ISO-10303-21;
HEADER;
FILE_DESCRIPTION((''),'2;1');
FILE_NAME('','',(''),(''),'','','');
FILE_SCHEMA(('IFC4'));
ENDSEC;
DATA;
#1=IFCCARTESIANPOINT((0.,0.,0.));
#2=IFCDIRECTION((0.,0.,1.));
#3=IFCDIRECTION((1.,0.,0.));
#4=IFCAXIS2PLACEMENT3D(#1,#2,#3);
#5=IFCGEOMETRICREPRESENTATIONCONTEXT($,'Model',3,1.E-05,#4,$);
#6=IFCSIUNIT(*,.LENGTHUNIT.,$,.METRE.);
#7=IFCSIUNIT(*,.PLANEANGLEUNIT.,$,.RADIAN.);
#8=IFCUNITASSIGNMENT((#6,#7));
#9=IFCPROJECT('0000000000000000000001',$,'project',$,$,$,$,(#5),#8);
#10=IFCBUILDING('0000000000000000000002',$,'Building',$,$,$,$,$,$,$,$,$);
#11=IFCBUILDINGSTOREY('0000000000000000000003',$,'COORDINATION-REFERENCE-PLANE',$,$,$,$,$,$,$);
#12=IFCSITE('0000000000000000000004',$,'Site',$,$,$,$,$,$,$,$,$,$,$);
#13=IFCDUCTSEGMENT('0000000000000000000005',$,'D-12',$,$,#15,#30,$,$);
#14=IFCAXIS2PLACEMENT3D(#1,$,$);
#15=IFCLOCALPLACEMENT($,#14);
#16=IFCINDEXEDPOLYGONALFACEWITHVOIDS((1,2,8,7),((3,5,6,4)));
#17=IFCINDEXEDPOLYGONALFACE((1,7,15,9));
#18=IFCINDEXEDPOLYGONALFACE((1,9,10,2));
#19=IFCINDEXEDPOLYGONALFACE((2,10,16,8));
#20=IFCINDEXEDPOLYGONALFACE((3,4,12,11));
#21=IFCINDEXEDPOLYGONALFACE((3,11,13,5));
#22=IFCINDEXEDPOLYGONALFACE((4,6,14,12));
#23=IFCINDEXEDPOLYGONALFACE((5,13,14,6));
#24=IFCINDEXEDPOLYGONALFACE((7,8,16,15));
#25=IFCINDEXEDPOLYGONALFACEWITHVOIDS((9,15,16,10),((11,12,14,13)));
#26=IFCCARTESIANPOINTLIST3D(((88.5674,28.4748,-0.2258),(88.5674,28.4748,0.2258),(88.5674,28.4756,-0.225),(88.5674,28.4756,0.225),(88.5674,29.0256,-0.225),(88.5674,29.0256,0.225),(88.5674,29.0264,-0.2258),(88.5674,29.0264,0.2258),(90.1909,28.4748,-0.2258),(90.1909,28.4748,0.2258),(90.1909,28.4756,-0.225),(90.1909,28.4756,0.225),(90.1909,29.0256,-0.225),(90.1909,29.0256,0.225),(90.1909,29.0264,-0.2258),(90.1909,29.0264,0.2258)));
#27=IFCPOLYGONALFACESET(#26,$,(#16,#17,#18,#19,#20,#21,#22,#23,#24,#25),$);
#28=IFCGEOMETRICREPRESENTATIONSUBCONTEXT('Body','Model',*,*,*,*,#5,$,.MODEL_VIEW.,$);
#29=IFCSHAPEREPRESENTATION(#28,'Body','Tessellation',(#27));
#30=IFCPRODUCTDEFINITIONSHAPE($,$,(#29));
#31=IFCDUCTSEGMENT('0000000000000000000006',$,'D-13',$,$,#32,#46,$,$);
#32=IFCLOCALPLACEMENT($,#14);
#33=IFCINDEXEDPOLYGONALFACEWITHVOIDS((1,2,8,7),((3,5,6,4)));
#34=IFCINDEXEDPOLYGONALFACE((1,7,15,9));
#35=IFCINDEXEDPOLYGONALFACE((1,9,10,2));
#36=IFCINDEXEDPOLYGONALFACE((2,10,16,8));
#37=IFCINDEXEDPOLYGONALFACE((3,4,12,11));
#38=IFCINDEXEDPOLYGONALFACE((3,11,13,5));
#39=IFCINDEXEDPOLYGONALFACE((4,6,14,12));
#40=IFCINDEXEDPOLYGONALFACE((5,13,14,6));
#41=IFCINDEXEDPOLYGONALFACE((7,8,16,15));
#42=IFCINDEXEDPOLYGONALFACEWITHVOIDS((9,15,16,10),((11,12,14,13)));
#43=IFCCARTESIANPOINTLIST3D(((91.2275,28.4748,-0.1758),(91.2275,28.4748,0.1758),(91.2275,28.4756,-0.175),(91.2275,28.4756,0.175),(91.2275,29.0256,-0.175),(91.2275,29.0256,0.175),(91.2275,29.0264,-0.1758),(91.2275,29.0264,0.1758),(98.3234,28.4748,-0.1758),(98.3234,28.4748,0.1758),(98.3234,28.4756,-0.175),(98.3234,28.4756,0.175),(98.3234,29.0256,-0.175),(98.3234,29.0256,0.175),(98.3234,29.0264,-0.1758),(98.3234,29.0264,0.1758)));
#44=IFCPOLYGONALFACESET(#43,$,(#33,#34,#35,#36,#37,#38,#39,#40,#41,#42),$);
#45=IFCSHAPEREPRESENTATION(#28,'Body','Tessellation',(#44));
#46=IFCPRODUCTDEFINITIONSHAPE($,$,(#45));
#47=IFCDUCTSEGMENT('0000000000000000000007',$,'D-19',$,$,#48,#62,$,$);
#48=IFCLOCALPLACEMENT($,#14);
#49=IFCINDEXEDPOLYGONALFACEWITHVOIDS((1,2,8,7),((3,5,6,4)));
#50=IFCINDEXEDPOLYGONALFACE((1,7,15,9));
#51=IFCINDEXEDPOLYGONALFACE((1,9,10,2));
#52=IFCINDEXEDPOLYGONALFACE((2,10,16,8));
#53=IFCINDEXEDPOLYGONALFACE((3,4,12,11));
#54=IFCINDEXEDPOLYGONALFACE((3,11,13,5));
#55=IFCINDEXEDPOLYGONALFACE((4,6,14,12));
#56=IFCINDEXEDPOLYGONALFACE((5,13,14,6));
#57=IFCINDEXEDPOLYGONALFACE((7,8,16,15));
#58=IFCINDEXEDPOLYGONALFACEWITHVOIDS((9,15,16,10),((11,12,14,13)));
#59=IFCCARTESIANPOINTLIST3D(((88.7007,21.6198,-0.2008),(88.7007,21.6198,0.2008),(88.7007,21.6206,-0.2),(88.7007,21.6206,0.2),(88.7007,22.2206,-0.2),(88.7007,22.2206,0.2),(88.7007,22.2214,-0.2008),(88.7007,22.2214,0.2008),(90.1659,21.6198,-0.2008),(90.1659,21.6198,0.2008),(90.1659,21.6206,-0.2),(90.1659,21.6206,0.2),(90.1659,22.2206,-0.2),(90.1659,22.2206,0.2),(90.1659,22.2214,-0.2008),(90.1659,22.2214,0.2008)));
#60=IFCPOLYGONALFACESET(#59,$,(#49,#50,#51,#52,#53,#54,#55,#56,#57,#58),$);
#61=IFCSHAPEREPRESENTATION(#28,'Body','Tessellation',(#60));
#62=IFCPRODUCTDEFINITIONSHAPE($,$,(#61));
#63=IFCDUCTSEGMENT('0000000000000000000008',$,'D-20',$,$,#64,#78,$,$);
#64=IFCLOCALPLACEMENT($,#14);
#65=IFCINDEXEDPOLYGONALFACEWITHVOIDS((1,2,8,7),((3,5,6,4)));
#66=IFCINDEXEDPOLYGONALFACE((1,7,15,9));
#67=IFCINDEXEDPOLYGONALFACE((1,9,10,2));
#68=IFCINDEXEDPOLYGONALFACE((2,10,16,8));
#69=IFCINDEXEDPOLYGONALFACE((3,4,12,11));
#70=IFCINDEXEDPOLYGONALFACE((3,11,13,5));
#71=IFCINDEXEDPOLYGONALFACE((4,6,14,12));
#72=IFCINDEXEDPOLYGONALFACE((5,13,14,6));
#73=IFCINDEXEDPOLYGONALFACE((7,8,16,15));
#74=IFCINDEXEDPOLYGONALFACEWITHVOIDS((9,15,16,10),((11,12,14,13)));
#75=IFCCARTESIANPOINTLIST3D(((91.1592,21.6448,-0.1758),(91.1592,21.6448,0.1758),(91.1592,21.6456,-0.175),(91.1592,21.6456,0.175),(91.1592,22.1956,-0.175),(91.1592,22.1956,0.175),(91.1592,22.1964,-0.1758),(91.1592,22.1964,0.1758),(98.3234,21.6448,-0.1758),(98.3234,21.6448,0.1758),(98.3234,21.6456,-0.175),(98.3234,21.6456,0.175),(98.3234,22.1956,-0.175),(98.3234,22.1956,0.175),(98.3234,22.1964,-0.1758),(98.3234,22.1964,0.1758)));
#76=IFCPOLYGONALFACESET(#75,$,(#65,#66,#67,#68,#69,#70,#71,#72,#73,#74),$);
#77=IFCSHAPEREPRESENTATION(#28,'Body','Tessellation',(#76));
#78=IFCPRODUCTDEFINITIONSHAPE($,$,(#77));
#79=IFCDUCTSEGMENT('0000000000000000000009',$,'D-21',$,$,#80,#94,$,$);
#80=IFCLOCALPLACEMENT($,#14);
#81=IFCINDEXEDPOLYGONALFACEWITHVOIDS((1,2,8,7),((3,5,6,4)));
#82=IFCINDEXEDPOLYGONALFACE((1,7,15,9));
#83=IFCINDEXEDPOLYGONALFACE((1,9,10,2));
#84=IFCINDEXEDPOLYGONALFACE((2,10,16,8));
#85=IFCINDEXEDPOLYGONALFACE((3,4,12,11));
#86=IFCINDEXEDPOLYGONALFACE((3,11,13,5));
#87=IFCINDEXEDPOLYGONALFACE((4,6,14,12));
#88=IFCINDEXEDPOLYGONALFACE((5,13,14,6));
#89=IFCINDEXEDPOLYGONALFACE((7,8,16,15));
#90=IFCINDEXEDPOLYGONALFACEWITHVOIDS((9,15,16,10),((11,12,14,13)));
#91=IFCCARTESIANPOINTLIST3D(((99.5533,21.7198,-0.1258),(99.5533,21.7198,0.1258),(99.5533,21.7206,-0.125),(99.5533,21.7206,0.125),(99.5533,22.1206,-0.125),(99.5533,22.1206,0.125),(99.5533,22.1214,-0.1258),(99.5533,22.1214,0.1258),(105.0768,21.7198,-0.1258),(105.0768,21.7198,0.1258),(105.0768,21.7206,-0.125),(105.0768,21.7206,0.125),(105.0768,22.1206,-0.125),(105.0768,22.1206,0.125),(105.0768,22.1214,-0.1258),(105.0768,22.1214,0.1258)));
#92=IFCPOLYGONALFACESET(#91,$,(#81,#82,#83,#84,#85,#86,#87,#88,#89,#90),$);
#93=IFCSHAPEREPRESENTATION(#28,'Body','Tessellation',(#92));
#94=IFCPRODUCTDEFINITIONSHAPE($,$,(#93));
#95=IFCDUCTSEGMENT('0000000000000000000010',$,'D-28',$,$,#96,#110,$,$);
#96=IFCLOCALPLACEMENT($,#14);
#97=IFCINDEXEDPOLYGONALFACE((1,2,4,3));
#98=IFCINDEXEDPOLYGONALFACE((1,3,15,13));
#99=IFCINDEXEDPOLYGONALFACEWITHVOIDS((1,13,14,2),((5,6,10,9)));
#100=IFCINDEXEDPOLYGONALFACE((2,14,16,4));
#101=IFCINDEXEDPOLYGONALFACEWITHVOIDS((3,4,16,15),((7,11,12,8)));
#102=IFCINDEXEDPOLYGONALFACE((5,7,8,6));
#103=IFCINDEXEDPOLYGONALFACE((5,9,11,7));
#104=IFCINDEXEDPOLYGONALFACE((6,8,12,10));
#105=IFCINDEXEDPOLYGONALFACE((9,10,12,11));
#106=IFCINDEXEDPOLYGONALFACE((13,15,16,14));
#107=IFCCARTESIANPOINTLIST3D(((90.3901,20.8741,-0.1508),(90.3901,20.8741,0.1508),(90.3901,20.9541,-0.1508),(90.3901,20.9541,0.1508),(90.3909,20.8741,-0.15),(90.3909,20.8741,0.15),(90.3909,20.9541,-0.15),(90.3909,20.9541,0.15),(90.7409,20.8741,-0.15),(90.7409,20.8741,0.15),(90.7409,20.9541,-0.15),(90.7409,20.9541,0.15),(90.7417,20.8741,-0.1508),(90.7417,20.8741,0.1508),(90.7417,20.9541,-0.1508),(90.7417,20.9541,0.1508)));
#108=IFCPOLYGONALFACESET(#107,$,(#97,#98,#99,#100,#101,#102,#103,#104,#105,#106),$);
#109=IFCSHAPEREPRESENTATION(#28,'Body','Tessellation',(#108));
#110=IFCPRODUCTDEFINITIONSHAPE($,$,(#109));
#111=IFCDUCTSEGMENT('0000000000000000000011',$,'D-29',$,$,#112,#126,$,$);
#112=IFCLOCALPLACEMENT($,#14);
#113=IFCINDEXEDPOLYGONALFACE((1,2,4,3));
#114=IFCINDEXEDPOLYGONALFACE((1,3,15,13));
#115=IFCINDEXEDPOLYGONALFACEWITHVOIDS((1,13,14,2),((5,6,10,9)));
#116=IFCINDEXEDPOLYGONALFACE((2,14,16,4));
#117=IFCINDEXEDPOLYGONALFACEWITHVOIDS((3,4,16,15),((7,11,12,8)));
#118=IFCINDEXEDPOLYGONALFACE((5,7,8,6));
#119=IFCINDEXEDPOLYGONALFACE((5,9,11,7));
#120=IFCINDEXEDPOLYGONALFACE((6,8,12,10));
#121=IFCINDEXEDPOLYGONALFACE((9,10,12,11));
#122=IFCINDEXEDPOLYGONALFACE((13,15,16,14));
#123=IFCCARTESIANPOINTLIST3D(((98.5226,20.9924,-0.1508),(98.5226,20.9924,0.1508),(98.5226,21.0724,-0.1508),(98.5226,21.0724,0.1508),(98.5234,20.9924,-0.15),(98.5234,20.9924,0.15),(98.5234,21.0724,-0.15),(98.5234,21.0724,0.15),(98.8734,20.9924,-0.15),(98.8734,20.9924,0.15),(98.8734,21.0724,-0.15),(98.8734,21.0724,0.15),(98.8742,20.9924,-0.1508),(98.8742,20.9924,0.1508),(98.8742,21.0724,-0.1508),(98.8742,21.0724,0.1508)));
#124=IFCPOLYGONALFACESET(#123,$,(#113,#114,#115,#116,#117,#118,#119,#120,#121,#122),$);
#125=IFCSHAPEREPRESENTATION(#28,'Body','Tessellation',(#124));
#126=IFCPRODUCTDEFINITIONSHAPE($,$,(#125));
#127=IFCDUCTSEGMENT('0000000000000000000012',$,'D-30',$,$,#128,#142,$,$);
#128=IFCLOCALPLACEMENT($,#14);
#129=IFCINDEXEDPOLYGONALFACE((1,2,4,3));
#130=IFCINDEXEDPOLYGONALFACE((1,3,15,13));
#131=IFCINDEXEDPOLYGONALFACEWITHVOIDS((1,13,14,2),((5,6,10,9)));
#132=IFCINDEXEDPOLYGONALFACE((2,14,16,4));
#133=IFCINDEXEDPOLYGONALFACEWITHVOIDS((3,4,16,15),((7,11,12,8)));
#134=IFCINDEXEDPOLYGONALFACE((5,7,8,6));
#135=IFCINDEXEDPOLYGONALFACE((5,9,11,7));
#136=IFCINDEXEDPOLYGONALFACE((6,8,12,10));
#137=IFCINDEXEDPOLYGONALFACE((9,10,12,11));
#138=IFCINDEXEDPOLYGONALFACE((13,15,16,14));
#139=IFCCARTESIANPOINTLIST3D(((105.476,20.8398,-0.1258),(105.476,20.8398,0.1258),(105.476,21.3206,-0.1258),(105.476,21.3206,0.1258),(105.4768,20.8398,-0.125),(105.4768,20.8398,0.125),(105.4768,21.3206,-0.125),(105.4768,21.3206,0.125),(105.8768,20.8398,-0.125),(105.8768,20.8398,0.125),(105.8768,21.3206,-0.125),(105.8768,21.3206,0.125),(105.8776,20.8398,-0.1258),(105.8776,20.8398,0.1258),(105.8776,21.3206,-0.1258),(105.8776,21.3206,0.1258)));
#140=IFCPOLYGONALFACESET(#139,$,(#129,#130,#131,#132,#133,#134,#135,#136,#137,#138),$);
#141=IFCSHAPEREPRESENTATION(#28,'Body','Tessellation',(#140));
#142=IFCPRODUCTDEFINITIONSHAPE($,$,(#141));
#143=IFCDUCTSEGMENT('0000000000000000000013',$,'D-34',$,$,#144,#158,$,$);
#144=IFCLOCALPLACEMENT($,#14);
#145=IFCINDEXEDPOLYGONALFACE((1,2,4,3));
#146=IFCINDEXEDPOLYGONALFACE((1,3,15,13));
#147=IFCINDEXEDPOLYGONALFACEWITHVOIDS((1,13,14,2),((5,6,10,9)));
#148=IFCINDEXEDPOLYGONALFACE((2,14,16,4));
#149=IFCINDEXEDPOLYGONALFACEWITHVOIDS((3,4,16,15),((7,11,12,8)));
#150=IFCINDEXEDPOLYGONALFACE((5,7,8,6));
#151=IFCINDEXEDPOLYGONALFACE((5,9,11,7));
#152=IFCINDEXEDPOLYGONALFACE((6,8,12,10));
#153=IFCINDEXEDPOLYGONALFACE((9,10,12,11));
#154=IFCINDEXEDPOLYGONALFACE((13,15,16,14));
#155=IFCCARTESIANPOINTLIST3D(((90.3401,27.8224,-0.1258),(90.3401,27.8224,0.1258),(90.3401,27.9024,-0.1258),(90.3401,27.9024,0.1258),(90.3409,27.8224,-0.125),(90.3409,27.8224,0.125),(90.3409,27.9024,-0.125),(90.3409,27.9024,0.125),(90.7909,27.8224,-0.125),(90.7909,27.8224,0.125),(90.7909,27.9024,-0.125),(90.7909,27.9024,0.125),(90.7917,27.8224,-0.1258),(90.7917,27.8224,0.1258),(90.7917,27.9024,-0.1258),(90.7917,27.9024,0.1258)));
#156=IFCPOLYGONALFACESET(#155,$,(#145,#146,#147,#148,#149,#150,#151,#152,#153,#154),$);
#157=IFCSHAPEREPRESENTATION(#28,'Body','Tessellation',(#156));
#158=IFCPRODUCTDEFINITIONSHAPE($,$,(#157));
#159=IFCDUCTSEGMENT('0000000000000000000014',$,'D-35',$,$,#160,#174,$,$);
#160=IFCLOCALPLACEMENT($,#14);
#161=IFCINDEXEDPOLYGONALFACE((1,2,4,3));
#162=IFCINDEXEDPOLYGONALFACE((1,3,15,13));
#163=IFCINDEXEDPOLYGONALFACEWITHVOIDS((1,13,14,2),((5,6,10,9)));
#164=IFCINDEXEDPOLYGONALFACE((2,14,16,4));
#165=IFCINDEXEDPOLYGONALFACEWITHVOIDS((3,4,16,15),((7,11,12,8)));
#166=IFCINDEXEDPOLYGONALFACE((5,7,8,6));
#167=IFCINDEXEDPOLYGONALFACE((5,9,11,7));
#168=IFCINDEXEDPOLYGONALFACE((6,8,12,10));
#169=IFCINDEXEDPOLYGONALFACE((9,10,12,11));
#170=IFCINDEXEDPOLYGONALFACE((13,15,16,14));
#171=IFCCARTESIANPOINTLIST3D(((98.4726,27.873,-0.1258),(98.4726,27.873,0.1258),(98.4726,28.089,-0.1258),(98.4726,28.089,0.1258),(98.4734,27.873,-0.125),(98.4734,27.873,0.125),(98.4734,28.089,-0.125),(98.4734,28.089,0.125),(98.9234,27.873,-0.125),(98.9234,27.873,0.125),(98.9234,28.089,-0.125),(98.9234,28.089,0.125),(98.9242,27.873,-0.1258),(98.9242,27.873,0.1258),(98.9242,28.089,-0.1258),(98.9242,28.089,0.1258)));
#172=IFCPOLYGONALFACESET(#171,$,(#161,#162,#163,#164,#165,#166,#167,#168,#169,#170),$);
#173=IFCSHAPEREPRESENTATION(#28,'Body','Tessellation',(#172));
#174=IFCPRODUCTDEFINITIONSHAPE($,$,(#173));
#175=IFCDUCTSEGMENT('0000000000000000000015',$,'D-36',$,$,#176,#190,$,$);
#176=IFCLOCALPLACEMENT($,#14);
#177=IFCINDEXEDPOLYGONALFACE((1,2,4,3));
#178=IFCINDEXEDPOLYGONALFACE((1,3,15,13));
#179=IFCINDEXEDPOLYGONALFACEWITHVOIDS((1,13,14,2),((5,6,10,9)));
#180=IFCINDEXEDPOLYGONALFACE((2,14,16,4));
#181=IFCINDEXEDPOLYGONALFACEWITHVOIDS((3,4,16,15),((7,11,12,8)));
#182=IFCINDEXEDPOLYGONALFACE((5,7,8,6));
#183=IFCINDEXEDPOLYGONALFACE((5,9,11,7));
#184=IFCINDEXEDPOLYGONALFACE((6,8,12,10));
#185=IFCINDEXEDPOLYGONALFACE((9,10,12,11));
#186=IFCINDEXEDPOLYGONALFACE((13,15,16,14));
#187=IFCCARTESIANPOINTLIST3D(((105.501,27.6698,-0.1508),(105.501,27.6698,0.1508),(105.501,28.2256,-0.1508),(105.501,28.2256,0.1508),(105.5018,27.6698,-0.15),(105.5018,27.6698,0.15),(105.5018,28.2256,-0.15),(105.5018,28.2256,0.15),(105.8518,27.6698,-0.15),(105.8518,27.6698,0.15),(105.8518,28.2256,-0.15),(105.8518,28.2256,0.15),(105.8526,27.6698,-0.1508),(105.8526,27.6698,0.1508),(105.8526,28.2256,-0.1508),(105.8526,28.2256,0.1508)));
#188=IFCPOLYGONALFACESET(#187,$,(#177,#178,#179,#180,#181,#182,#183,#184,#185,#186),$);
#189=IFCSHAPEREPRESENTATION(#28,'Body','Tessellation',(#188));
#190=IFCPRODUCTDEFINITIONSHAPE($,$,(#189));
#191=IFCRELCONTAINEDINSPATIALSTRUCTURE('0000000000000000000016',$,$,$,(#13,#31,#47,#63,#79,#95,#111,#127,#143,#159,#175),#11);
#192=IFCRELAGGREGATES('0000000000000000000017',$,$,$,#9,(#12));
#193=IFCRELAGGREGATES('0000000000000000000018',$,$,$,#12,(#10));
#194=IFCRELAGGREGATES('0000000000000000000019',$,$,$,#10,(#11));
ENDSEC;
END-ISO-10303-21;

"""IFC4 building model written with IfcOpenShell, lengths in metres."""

from ifc_helpers import new_model, si_unit, frame, origin, origin_with_axes, place, context, subcontext, project, spatial, hollow_rectangle, extrude, element, save


model = new_model("IFC4")

# Units and contexts
model_context = context("Model", 3, precision=1e-05, world=origin_with_axes())
body_context_1 = subcontext(model_context, "Body", "Model", "MODEL_VIEW")
ifc_project = project(units=[si_unit("LENGTHUNIT", "METRE"), si_unit("PLANEANGLEUNIT", "RADIAN")], contexts=[model_context])

# Site, building, storey
site = spatial("IfcSite", under=ifc_project, Name="Site")
building = spatial("IfcBuilding", under=site, Name="Building")
storey = spatial("IfcBuildingStorey", under=building, Name="COORDINATION-REFERENCE-PLANE")

# Duct segments
duct_segment_1_placement = place(None, frame((88.5674, 28.7506, 0.0), z_axis=(1.0, 0.0, 0.0), x_axis=(0.0, 1.0, 0.0)))
element("IfcDuctSegment", 1, at=duct_segment_1_placement, inside=storey, Name="D-12", context=body_context_1, shape_type="SweptSolid", body=[
    extrude(hollow_rectangle(XDim=0.5516, YDim=0.4516, WallThickness=0.0008), origin(), (0.0, 0.0, 1.0), 1.6235),
])
duct_segment_2_placement = place(None, frame((91.2275, 28.7506, 0.0), z_axis=(1.0, 0.0, 0.0), x_axis=(0.0, 1.0, 0.0)))
element("IfcDuctSegment", 2, at=duct_segment_2_placement, inside=storey, Name="D-13", context=body_context_1, shape_type="SweptSolid", body=[
    extrude(hollow_rectangle(XDim=0.5516, YDim=0.3516, WallThickness=0.0008), origin(), (0.0, 0.0, 1.0), 7.0959),
])
duct_segment_3_placement = place(None, frame((88.7007, 21.9206, 0.0), z_axis=(1.0, 0.0, 0.0), x_axis=(0.0, 1.0, 0.0)))
element("IfcDuctSegment", 3, at=duct_segment_3_placement, inside=storey, Name="D-19", context=body_context_1, shape_type="SweptSolid", body=[
    extrude(hollow_rectangle(XDim=0.6016, YDim=0.4016, WallThickness=0.0008), origin(), (0.0, 0.0, 1.0), 1.4652),
])
duct_segment_4_placement = place(None, frame((91.1592, 21.9206, 0.0), z_axis=(1.0, 0.0, 0.0), x_axis=(0.0, 1.0, 0.0)))
element("IfcDuctSegment", 4, at=duct_segment_4_placement, inside=storey, Name="D-20", context=body_context_1, shape_type="SweptSolid", body=[
    extrude(hollow_rectangle(XDim=0.5516, YDim=0.3516, WallThickness=0.0008), origin(), (0.0, 0.0, 1.0), 7.1642),
])
duct_segment_5_placement = place(None, frame((99.5533, 21.9206, 0.0), z_axis=(1.0, 0.0, 0.0), x_axis=(0.0, 1.0, 0.0)))
element("IfcDuctSegment", 5, at=duct_segment_5_placement, inside=storey, Name="D-21", context=body_context_1, shape_type="SweptSolid", body=[
    extrude(hollow_rectangle(XDim=0.4016, YDim=0.2516, WallThickness=0.0008), origin(), (0.0, 0.0, 1.0), 5.5234),
])
for number, where, z_axis, x_axis, name in (
    (6, (90.5659, 20.8741, 0.0), (0.0, 1.0, 0.0), (1.0, 0.0, 0.0), "D-28"),
    (7, (98.6984, 20.9924, 0.0), (0.0, 1.0, 0.0), (1.0, 0.0, 0.0), "D-29"),
):
    element("IfcDuctSegment", number, at=place(None, frame(where, z_axis=z_axis, x_axis=x_axis)), inside=storey, Name=name, context=body_context_1, shape_type="SweptSolid", body=[
        extrude(hollow_rectangle(XDim=0.3516, YDim=0.3016, WallThickness=0.0008), origin(), (0.0, 0.0, 1.0), 0.08),
    ])
duct_segment_6_placement = place(None, frame((105.6768, 20.8398, 0.0), z_axis=(0.0, 1.0, 0.0), x_axis=(1.0, 0.0, 0.0)))
element("IfcDuctSegment", 8, at=duct_segment_6_placement, inside=storey, Name="D-30", context=body_context_1, shape_type="SweptSolid", body=[
    extrude(hollow_rectangle(XDim=0.4016, YDim=0.2516, WallThickness=0.0008), origin(), (0.0, 0.0, 1.0), 0.4808),
])
duct_segment_7_placement = place(None, frame((90.5659, 27.8224, 0.0), z_axis=(0.0, 1.0, 0.0), x_axis=(1.0, 0.0, 0.0)))
element("IfcDuctSegment", 9, at=duct_segment_7_placement, inside=storey, Name="D-34", context=body_context_1, shape_type="SweptSolid", body=[
    extrude(hollow_rectangle(XDim=0.4516, YDim=0.2516, WallThickness=0.0008), origin(), (0.0, 0.0, 1.0), 0.08),
])
duct_segment_8_placement = place(None, frame((98.6984, 27.873, 0.0), z_axis=(0.0, 1.0, 0.0), x_axis=(1.0, 0.0, 0.0)))
element("IfcDuctSegment", 10, at=duct_segment_8_placement, inside=storey, Name="D-35", context=body_context_1, shape_type="SweptSolid", body=[
    extrude(hollow_rectangle(XDim=0.4516, YDim=0.2516, WallThickness=0.0008), origin(), (0.0, 0.0, 1.0), 0.216),
])
duct_segment_9_placement = place(None, frame((105.6768, 27.6698, 0.0), z_axis=(0.0, 1.0, 0.0), x_axis=(1.0, 0.0, 0.0)))
element("IfcDuctSegment", 11, at=duct_segment_9_placement, inside=storey, Name="D-36", context=body_context_1, shape_type="SweptSolid", body=[
    extrude(hollow_rectangle(XDim=0.3516, YDim=0.3016, WallThickness=0.0008), origin(), (0.0, 0.0, 1.0), 0.5558),
])

save(model, "model.ifc")
